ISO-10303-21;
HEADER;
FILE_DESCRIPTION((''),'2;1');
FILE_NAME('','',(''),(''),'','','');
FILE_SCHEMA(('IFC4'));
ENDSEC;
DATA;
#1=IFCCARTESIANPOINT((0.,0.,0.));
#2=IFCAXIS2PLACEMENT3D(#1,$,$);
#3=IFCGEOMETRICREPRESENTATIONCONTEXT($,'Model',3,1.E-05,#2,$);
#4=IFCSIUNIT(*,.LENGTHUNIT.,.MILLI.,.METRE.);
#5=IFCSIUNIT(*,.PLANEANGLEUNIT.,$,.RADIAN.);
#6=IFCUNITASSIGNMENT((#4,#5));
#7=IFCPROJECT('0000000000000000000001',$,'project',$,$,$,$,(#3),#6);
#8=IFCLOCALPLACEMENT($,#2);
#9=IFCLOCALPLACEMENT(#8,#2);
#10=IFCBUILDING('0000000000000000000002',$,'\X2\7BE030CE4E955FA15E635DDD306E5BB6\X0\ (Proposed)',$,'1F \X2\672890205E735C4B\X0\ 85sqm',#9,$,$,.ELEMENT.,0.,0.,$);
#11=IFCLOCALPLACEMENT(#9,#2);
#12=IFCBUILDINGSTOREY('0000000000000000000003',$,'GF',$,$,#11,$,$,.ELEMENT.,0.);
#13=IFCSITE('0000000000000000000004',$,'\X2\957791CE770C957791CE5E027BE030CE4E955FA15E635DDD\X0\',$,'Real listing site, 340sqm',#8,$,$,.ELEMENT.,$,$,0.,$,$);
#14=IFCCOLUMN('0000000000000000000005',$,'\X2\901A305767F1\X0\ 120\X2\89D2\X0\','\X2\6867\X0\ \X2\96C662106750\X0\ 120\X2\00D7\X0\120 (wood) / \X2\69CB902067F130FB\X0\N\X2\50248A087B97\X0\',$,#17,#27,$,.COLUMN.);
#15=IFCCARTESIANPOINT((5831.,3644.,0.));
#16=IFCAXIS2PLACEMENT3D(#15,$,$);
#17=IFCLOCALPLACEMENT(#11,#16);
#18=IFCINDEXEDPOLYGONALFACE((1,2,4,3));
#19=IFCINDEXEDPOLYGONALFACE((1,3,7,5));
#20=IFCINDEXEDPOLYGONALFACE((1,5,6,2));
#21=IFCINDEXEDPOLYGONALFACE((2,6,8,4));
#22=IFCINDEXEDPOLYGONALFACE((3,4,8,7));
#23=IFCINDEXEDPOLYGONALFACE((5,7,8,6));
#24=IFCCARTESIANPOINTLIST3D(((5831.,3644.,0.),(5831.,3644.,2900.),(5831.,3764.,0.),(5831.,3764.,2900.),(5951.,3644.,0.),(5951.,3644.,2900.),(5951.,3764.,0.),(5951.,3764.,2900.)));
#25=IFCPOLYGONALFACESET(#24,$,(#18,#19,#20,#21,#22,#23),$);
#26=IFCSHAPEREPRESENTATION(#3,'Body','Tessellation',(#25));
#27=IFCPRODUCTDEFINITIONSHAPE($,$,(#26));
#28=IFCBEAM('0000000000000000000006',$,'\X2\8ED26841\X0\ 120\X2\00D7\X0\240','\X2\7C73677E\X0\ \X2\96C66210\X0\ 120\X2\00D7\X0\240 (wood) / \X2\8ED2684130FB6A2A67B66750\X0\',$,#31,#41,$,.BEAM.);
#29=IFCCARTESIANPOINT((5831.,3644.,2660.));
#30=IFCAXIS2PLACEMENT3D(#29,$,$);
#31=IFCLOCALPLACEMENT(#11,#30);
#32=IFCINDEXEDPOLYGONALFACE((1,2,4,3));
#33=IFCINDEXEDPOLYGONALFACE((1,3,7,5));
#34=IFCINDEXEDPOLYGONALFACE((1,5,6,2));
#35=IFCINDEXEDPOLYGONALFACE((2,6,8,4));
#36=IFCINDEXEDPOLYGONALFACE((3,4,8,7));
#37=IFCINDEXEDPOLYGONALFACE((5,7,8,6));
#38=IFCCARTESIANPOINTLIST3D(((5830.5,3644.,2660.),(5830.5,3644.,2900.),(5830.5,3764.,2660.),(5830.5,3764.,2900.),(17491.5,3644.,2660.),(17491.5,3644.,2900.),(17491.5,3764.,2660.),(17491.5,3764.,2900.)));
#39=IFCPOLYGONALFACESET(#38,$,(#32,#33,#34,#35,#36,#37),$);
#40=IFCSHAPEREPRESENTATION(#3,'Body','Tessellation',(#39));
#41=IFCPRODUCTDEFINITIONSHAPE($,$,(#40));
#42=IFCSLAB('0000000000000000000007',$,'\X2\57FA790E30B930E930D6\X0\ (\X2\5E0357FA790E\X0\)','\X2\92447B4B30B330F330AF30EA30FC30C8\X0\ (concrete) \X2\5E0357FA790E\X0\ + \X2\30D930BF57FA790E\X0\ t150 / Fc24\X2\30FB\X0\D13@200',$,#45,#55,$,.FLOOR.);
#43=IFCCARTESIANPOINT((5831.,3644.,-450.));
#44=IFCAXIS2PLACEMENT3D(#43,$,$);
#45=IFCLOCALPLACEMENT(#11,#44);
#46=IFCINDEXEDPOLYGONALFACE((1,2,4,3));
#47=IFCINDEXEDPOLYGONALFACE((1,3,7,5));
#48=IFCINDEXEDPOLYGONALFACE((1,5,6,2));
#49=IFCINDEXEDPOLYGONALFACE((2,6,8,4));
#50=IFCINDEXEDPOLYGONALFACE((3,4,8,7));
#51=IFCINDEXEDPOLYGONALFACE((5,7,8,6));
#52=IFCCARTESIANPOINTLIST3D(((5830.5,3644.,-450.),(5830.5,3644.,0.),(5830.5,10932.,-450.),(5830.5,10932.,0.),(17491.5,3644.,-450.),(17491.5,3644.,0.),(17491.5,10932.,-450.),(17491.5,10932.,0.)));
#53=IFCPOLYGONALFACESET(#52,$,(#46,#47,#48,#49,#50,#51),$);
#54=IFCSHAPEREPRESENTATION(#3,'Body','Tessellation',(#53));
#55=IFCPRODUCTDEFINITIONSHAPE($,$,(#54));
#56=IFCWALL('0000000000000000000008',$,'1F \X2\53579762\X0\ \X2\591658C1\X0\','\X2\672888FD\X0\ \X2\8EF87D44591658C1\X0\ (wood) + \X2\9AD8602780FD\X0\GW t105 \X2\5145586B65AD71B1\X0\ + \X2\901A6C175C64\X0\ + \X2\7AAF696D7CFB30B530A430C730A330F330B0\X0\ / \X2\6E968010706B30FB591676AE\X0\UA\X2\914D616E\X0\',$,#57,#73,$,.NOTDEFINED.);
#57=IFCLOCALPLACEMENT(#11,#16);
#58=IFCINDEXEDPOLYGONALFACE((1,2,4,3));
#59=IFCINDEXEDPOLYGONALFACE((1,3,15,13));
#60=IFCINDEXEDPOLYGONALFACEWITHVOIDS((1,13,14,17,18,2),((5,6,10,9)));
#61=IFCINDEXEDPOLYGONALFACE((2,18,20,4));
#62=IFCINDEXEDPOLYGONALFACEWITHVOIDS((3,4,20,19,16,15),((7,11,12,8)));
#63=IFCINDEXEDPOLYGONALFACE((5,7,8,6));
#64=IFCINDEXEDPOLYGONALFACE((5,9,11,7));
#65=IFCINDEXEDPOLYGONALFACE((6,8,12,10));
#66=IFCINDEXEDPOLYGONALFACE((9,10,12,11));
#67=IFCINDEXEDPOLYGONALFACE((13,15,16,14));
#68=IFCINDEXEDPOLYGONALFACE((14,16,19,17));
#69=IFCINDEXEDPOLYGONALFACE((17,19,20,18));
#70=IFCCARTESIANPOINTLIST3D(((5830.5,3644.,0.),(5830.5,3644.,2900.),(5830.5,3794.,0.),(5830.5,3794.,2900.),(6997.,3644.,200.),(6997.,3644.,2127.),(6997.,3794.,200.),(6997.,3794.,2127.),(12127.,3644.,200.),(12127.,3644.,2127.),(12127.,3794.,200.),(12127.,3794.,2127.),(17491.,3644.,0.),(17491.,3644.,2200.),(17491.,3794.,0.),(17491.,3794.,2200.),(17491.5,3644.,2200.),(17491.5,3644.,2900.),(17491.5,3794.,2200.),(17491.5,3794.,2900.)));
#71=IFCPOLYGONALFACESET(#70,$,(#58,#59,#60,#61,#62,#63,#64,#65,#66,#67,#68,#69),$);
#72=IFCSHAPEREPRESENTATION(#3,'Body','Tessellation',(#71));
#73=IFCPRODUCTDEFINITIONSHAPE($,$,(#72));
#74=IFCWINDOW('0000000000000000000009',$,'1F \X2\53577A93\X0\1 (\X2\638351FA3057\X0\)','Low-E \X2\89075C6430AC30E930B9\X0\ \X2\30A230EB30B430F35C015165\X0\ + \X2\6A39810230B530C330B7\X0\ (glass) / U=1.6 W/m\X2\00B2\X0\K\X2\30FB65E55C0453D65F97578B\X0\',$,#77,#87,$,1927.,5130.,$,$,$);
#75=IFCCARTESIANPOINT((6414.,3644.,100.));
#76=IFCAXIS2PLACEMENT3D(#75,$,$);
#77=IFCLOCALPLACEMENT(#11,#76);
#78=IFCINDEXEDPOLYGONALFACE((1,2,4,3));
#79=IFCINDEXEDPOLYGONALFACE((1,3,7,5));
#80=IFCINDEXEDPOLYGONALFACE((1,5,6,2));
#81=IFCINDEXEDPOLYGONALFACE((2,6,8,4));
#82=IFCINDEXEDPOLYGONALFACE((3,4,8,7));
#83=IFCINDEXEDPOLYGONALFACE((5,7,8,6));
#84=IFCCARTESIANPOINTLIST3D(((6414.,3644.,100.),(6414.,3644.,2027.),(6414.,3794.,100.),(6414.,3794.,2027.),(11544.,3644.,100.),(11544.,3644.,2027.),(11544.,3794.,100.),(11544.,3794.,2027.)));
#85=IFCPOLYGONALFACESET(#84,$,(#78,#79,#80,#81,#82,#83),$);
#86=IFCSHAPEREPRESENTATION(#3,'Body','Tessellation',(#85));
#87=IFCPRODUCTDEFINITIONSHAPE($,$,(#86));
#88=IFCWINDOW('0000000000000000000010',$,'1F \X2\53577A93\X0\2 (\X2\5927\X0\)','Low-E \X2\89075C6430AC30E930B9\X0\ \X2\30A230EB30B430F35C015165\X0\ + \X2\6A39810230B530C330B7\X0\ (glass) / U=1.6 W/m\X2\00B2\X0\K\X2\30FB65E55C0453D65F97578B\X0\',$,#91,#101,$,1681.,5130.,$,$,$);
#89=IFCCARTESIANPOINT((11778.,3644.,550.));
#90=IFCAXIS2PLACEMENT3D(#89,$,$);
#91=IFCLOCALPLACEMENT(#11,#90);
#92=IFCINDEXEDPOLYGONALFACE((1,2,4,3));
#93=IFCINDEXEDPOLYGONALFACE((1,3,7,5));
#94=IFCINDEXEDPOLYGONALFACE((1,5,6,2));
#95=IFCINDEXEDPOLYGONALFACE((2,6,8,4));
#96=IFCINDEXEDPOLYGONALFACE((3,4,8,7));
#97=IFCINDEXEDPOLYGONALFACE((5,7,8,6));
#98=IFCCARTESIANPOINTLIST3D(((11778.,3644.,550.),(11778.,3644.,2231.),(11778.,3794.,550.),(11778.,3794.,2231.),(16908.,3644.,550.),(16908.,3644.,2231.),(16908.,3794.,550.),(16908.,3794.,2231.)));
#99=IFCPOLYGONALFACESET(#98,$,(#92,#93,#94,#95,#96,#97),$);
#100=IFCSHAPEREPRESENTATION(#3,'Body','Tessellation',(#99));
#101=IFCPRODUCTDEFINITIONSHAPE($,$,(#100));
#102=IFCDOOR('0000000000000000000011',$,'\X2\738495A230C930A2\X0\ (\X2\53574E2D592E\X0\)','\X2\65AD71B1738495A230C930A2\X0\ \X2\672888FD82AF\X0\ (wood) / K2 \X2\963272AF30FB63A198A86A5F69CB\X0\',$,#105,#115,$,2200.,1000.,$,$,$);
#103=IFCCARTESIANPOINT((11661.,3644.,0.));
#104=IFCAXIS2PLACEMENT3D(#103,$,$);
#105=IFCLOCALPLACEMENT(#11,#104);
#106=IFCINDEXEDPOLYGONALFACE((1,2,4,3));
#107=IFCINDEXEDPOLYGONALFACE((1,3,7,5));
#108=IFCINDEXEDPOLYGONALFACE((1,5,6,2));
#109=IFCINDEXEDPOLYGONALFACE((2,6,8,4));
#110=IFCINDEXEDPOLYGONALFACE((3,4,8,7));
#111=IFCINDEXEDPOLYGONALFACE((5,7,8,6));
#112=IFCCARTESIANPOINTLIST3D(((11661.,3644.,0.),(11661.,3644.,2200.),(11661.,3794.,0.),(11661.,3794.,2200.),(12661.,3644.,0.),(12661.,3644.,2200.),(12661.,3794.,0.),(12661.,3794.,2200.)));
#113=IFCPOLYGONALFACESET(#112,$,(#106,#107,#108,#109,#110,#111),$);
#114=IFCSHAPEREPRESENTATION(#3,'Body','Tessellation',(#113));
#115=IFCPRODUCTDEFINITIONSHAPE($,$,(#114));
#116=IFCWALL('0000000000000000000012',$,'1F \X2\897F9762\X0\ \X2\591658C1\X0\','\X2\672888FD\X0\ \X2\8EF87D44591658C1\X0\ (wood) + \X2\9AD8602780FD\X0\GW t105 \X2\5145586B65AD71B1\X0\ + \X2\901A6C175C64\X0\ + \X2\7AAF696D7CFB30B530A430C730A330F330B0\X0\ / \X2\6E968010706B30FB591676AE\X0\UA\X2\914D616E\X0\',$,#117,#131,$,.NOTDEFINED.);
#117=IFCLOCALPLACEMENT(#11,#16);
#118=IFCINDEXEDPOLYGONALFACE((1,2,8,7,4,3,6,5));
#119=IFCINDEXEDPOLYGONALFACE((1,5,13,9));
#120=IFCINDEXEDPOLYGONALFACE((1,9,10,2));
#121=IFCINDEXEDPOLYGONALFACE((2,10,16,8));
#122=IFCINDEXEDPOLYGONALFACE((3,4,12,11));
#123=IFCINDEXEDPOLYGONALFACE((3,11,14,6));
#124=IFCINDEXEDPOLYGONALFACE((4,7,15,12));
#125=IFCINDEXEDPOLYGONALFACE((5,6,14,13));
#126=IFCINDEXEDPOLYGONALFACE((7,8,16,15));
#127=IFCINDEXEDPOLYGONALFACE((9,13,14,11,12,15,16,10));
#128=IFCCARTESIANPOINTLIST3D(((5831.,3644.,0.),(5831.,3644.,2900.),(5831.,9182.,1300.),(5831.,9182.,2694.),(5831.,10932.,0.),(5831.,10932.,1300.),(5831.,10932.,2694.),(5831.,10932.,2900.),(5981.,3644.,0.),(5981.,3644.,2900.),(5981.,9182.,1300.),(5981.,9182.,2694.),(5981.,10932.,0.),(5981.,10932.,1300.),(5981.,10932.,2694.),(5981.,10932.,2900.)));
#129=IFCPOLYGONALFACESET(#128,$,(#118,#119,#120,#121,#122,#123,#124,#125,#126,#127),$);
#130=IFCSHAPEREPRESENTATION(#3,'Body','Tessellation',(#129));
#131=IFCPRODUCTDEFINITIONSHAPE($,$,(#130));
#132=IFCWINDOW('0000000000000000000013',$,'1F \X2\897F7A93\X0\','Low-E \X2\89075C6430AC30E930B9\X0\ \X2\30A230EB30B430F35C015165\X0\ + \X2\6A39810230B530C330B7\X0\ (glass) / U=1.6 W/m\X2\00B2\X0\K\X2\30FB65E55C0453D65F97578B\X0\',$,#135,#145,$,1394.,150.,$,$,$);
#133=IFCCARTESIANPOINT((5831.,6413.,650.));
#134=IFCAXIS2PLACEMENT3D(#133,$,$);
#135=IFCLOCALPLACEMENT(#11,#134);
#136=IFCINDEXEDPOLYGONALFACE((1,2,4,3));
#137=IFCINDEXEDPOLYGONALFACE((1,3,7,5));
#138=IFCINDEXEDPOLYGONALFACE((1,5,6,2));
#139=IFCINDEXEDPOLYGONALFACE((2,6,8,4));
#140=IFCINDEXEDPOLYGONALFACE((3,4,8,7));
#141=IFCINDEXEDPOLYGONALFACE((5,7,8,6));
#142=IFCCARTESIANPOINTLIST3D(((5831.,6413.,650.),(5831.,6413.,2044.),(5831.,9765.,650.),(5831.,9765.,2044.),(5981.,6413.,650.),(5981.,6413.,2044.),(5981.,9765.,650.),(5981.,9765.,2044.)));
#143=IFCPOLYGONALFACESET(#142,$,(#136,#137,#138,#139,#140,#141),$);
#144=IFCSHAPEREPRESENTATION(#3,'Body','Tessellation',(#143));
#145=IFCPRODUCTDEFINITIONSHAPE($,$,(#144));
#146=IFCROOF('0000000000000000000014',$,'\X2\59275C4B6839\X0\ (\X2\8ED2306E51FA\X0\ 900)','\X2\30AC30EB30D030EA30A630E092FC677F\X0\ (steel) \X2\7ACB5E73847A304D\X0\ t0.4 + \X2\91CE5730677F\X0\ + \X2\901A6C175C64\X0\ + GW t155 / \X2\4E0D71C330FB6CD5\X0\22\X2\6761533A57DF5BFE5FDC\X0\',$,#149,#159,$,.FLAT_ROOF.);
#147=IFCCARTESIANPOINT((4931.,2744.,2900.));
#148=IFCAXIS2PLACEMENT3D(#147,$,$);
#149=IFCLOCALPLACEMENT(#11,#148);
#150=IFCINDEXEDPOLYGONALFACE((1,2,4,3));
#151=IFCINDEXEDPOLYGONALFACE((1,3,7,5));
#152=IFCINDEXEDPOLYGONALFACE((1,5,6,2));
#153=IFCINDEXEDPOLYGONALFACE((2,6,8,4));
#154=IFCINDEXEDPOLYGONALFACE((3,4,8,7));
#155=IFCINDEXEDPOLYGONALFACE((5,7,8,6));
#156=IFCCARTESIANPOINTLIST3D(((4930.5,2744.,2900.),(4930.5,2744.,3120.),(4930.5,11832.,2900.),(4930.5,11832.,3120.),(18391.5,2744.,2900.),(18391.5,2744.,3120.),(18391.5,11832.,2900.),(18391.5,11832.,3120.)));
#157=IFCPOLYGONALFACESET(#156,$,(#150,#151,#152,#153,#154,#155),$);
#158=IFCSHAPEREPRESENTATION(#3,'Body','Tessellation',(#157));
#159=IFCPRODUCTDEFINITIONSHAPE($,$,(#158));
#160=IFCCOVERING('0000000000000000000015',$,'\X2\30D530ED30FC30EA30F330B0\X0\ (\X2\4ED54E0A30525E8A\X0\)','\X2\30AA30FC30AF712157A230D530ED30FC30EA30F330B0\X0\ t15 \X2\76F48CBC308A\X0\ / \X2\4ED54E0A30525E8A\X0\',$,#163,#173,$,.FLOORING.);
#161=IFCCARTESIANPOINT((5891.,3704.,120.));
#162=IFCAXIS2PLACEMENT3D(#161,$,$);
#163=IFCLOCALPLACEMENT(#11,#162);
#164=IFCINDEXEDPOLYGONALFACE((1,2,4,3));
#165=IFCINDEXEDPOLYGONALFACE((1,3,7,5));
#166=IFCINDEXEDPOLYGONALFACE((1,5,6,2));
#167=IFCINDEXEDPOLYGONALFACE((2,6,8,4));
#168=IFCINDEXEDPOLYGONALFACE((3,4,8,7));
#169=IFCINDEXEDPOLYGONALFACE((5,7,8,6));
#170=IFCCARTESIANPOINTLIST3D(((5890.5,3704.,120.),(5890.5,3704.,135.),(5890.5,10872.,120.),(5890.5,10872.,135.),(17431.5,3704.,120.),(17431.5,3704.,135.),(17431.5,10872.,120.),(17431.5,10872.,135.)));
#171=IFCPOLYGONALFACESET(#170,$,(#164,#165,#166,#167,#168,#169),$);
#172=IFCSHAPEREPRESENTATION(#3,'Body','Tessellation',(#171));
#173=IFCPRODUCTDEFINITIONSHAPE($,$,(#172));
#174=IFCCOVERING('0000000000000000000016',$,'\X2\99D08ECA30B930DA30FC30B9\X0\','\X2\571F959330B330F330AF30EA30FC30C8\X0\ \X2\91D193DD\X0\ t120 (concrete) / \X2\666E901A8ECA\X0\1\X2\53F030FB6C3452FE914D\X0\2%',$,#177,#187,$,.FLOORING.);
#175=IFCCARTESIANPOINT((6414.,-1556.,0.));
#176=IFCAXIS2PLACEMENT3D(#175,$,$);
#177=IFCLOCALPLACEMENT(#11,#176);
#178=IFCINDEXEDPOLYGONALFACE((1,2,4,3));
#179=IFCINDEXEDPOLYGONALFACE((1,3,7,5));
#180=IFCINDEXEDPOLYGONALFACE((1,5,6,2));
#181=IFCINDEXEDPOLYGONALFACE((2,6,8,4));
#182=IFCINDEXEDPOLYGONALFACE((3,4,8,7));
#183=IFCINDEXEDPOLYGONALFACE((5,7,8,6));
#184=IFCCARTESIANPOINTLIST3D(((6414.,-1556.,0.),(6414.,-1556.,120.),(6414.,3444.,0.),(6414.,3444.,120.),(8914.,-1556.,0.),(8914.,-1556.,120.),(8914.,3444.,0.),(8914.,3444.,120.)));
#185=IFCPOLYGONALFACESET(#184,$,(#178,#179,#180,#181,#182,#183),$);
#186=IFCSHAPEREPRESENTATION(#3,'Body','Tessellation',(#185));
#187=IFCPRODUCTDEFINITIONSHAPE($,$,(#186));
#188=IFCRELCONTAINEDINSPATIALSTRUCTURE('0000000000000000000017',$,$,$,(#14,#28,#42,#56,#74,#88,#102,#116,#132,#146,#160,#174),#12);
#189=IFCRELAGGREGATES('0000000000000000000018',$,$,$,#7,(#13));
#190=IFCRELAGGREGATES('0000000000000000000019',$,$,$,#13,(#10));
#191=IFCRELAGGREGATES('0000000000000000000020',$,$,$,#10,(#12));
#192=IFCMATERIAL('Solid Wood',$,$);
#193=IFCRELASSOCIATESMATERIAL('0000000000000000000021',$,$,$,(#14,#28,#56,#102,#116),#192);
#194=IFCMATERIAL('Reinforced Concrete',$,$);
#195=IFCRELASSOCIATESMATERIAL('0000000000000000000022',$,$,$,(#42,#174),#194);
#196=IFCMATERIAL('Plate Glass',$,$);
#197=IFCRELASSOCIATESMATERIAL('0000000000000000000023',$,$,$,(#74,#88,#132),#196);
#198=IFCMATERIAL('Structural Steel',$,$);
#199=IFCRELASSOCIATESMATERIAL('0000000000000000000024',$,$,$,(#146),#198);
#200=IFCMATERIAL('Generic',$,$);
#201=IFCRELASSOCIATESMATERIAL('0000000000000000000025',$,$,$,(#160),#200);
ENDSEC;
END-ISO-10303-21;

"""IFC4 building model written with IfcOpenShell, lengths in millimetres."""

from ifc_helpers import new_model, si_unit, frame, frame_2d, origin, place, context, project, spatial, rectangle, extrude, material, element, fill, save


model = new_model("IFC4")

# Units and contexts
model_context = context("Model", 3, precision=1e-05, world=origin())
ifc_project = project(units=[si_unit("LENGTHUNIT", "METRE", prefix="MILLI"), si_unit("PLANEANGLEUNIT", "RADIAN")], contexts=[model_context])

# Site, building, storey
site_placement = place(None, origin())
site = spatial("IfcSite", under=ifc_project, at=site_placement, Name="長野県長野市篠ノ井御幣川", ObjectType="Real listing site, 340sqm", CompositionType="ELEMENT", RefElevation=0.0)
building_placement = place(site_placement, origin())
building = spatial("IfcBuilding", under=site, at=building_placement, Name="篠ノ井御幣川の家 (Proposed)", ObjectType="1F 木造平屋 85sqm", CompositionType="ELEMENT", ElevationOfRefHeight=0.0, ElevationOfTerrain=0.0)
storey_placement = place(building_placement, origin())
storey = spatial("IfcBuildingStorey", under=building, at=storey_placement, Name="GF", CompositionType="ELEMENT", Elevation=0.0)

# Column
ifc_material_1 = material(Name="Solid Wood")
column_1_placement = place(storey_placement, frame((5831.0, 3644.0, 0.0)))
element("IfcColumn", 1, at=column_1_placement, inside=storey, material=ifc_material_1, Name="通し柱 120角", Description="桧 集成材 120×120 (wood) / 構造柱・N値計算", PredefinedType="COLUMN", context=model_context, shape_type="SweptSolid", body=[
    extrude(rectangle(XDim=120.0, YDim=120.0, at=frame_2d((60.0, 60.0))), frame((5831.0, 3644.0, 0.0)), (0.0, 0.0, 1.0), 2900.0),
])

# Beam
beam_1_placement = place(storey_placement, frame((5831.0, 3644.0, 2660.0)))
element("IfcBeam", 2, at=beam_1_placement, inside=storey, material=ifc_material_1, Name="軒桁 120×240", Description="米松 集成 120×240 (wood) / 軒桁・横架材", PredefinedType="BEAM", context=model_context, shape_type="SweptSolid", body=[
    extrude(rectangle(XDim=11661.0, YDim=120.0, at=frame_2d((5830.0, 60.0))), frame((5831.0, 3644.0, 2660.0)), (0.0, 0.0, 1.0), 240.0),
])

# Slab
ifc_material_2 = material(Name="Reinforced Concrete")
slab_1_placement = place(storey_placement, frame((5831.0, 3644.0, -450.0)))
element("IfcSlab", 3, at=slab_1_placement, inside=storey, material=ifc_material_2, Name="基礎スラブ (布基礎)", Description="鉄筋コンクリート (concrete) 布基礎 + ベタ基礎 t150 / Fc24・D13@200", PredefinedType="FLOOR", context=model_context, shape_type="SweptSolid", body=[
    extrude(rectangle(XDim=11661.0, YDim=7288.0, at=frame_2d((5830.0, 3644.0))), frame((5831.0, 3644.0, -450.0)), (0.0, 0.0, 1.0), 450.0),
])

# Wall, openings, windows, door
wall_1_placement = place(storey_placement, frame((5831.0, 3644.0, 0.0)))
wall_1 = element("IfcWall", 4, at=wall_1_placement, inside=storey, material=ifc_material_1, Name="1F 南面 外壁", Description="木製 軸組外壁 (wood) + 高性能GW t105 充填断熱 + 通気層 + 窯業系サイディング / 準耐火・外皮UA配慮", PredefinedType="NOTDEFINED", context=model_context, shape_type="SweptSolid", body=[
    extrude(rectangle(XDim=11661.0, YDim=150.0, at=frame_2d((5830.0, 75.0))), frame((5831.0, 3644.0, 0.0)), (0.0, 0.0, 1.0), 2900.0),
])
opening_1_placement = place(storey_placement, frame((6414.0, 3644.0, 100.0)))
opening_1 = element("IfcOpeningElement", 5, at=opening_1_placement, cuts=wall_1, PredefinedType="NOTDEFINED", context=model_context, shape_type="SweptSolid", body=[
    extrude(rectangle(XDim=5130.0, YDim=150.0, at=frame_2d((2565.0, 75.0))), frame((6414.0, 3644.0, 100.0)), (0.0, 0.0, 1.0), 1927.0),
])
opening_2_placement = place(storey_placement, frame((11778.0, 3644.0, 550.0)))
opening_2 = element("IfcOpeningElement", 6, at=opening_2_placement, cuts=wall_1, PredefinedType="NOTDEFINED", context=model_context, shape_type="SweptSolid", body=[
    extrude(rectangle(XDim=5130.0, YDim=150.0, at=frame_2d((2565.0, 75.0))), frame((11778.0, 3644.0, 550.0)), (0.0, 0.0, 1.0), 1681.0),
])
opening_3_placement = place(storey_placement, frame((11661.0, 3644.0, 0.0)))
opening_3 = element("IfcOpeningElement", 7, at=opening_3_placement, cuts=wall_1, PredefinedType="NOTDEFINED", context=model_context, shape_type="SweptSolid", body=[
    extrude(rectangle(XDim=1000.0, YDim=150.0, at=frame_2d((500.0, 75.0))), frame((11661.0, 3644.0, 0.0)), (0.0, 0.0, 1.0), 2200.0),
])
ifc_material_3 = material(Name="Plate Glass")
window_1_placement = place(storey_placement, frame((6414.0, 3644.0, 100.0)))
window_1 = element("IfcWindow", 8, at=window_1_placement, inside=storey, material=ifc_material_3, Name="1F 南窓1 (掃出し)", Description="Low-E 複層ガラス アルゴン封入 + 樹脂サッシ (glass) / U=1.6 W/m²K・日射取得型", OverallHeight=1927.0, OverallWidth=5130.0, context=model_context, shape_type="SweptSolid", body=[
    extrude(rectangle(XDim=5130.0, YDim=150.0, at=frame_2d((2565.0, 75.0))), frame((6414.0, 3644.0, 100.0)), (0.0, 0.0, 1.0), 1927.0),
])
fill(opening_1, window_1)
window_2_placement = place(storey_placement, frame((11778.0, 3644.0, 550.0)))
window_2 = element("IfcWindow", 9, at=window_2_placement, inside=storey, material=ifc_material_3, Name="1F 南窓2 (大)", Description="Low-E 複層ガラス アルゴン封入 + 樹脂サッシ (glass) / U=1.6 W/m²K・日射取得型", OverallHeight=1681.0, OverallWidth=5130.0, context=model_context, shape_type="SweptSolid", body=[
    extrude(rectangle(XDim=5130.0, YDim=150.0, at=frame_2d((2565.0, 75.0))), frame((11778.0, 3644.0, 550.0)), (0.0, 0.0, 1.0), 1681.0),
])
fill(opening_2, window_2)
door_placement = place(storey_placement, frame((11661.0, 3644.0, 0.0)))
door = element("IfcDoor", 10, at=door_placement, inside=storey, material=ifc_material_1, Name="玄関ドア (南中央)", Description="断熱玄関ドア 木製芯 (wood) / K2 防犯・採風機構", OverallHeight=2200.0, OverallWidth=1000.0, context=model_context, shape_type="SweptSolid", body=[
    extrude(rectangle(XDim=1000.0, YDim=150.0, at=frame_2d((500.0, 75.0))), frame((11661.0, 3644.0, 0.0)), (0.0, 0.0, 1.0), 2200.0),
])
fill(opening_3, door)

# Wall, opening, window
wall_2_placement = place(storey_placement, frame((5831.0, 3644.0, 0.0)))
wall_2 = element("IfcWall", 11, at=wall_2_placement, inside=storey, material=ifc_material_1, Name="1F 西面 外壁", Description="木製 軸組外壁 (wood) + 高性能GW t105 充填断熱 + 通気層 + 窯業系サイディング / 準耐火・外皮UA配慮", PredefinedType="NOTDEFINED", context=model_context, shape_type="SweptSolid", body=[
    extrude(rectangle(XDim=150.0, YDim=7288.0, at=frame_2d((75.0, 3644.0))), frame((5831.0, 3644.0, 0.0)), (0.0, 0.0, 1.0), 2900.0),
])
opening_4_placement = place(storey_placement, frame((5831.0, 6413.0, 650.0)))
opening_4 = element("IfcOpeningElement", 12, at=opening_4_placement, cuts=wall_2, PredefinedType="NOTDEFINED", context=model_context, shape_type="SweptSolid", body=[
    extrude(rectangle(XDim=150.0, YDim=3352.0, at=frame_2d((75.0, 1676.0))), frame((5831.0, 6413.0, 650.0)), (0.0, 0.0, 1.0), 1394.0),
])
window_3_placement = place(storey_placement, frame((5831.0, 6413.0, 650.0)))
window_3 = element("IfcWindow", 13, at=window_3_placement, inside=storey, material=ifc_material_3, Name="1F 西窓", Description="Low-E 複層ガラス アルゴン封入 + 樹脂サッシ (glass) / U=1.6 W/m²K・日射取得型", OverallHeight=1394.0, OverallWidth=150.0, context=model_context, shape_type="SweptSolid", body=[
    extrude(rectangle(XDim=150.0, YDim=3352.0, at=frame_2d((75.0, 1676.0))), frame((5831.0, 6413.0, 650.0)), (0.0, 0.0, 1.0), 1394.0),
])
fill(opening_4, window_3)

# Roof
ifc_material_4 = material(Name="Structural Steel")
roof_placement = place(storey_placement, frame((4931.0, 2744.0, 2900.0)))
element("IfcRoof", 14, at=roof_placement, inside=storey, material=ifc_material_4, Name="大屋根 (軒の出 900)", Description="ガルバリウム鋼板 (steel) 立平葺き t0.4 + 野地板 + 通気層 + GW t155 / 不燃・法22条区域対応", PredefinedType="FLAT_ROOF", context=model_context, shape_type="SweptSolid", body=[
    extrude(rectangle(XDim=13461.0, YDim=9088.0, at=frame_2d((6730.0, 4544.0))), frame((4931.0, 2744.0, 2900.0)), (0.0, 0.0, 1.0), 220.0),
])

# Coverings
ifc_material_5 = material(Name="Generic")
covering_1_placement = place(storey_placement, frame((5891.0, 3704.0, 120.0)))
element("IfcCovering", 15, at=covering_1_placement, inside=storey, material=ifc_material_5, Name="フローリング (仕上げ床)", Description="オーク無垢フローリング t15 直貼り / 仕上げ床", PredefinedType="FLOORING", context=model_context, shape_type="SweptSolid", body=[
    extrude(rectangle(XDim=11541.0, YDim=7168.0, at=frame_2d((5770.0, 3584.0))), frame((5891.0, 3704.0, 120.0)), (0.0, 0.0, 1.0), 15.0),
])
covering_2_placement = place(storey_placement, frame((6414.0, -1556.0, 0.0)))
element("IfcCovering", 16, at=covering_2_placement, inside=storey, material=ifc_material_2, Name="駐車スペース", Description="土間コンクリート 金鏝 t120 (concrete) / 普通車1台・水勾配2%", PredefinedType="FLOORING", context=model_context, shape_type="SweptSolid", body=[
    extrude(rectangle(XDim=2500.0, YDim=5000.0, at=frame_2d((1250.0, 2500.0))), frame((6414.0, -1556.0, 0.0)), (0.0, 0.0, 1.0), 120.0),
])

save(model, "model.ifc")
